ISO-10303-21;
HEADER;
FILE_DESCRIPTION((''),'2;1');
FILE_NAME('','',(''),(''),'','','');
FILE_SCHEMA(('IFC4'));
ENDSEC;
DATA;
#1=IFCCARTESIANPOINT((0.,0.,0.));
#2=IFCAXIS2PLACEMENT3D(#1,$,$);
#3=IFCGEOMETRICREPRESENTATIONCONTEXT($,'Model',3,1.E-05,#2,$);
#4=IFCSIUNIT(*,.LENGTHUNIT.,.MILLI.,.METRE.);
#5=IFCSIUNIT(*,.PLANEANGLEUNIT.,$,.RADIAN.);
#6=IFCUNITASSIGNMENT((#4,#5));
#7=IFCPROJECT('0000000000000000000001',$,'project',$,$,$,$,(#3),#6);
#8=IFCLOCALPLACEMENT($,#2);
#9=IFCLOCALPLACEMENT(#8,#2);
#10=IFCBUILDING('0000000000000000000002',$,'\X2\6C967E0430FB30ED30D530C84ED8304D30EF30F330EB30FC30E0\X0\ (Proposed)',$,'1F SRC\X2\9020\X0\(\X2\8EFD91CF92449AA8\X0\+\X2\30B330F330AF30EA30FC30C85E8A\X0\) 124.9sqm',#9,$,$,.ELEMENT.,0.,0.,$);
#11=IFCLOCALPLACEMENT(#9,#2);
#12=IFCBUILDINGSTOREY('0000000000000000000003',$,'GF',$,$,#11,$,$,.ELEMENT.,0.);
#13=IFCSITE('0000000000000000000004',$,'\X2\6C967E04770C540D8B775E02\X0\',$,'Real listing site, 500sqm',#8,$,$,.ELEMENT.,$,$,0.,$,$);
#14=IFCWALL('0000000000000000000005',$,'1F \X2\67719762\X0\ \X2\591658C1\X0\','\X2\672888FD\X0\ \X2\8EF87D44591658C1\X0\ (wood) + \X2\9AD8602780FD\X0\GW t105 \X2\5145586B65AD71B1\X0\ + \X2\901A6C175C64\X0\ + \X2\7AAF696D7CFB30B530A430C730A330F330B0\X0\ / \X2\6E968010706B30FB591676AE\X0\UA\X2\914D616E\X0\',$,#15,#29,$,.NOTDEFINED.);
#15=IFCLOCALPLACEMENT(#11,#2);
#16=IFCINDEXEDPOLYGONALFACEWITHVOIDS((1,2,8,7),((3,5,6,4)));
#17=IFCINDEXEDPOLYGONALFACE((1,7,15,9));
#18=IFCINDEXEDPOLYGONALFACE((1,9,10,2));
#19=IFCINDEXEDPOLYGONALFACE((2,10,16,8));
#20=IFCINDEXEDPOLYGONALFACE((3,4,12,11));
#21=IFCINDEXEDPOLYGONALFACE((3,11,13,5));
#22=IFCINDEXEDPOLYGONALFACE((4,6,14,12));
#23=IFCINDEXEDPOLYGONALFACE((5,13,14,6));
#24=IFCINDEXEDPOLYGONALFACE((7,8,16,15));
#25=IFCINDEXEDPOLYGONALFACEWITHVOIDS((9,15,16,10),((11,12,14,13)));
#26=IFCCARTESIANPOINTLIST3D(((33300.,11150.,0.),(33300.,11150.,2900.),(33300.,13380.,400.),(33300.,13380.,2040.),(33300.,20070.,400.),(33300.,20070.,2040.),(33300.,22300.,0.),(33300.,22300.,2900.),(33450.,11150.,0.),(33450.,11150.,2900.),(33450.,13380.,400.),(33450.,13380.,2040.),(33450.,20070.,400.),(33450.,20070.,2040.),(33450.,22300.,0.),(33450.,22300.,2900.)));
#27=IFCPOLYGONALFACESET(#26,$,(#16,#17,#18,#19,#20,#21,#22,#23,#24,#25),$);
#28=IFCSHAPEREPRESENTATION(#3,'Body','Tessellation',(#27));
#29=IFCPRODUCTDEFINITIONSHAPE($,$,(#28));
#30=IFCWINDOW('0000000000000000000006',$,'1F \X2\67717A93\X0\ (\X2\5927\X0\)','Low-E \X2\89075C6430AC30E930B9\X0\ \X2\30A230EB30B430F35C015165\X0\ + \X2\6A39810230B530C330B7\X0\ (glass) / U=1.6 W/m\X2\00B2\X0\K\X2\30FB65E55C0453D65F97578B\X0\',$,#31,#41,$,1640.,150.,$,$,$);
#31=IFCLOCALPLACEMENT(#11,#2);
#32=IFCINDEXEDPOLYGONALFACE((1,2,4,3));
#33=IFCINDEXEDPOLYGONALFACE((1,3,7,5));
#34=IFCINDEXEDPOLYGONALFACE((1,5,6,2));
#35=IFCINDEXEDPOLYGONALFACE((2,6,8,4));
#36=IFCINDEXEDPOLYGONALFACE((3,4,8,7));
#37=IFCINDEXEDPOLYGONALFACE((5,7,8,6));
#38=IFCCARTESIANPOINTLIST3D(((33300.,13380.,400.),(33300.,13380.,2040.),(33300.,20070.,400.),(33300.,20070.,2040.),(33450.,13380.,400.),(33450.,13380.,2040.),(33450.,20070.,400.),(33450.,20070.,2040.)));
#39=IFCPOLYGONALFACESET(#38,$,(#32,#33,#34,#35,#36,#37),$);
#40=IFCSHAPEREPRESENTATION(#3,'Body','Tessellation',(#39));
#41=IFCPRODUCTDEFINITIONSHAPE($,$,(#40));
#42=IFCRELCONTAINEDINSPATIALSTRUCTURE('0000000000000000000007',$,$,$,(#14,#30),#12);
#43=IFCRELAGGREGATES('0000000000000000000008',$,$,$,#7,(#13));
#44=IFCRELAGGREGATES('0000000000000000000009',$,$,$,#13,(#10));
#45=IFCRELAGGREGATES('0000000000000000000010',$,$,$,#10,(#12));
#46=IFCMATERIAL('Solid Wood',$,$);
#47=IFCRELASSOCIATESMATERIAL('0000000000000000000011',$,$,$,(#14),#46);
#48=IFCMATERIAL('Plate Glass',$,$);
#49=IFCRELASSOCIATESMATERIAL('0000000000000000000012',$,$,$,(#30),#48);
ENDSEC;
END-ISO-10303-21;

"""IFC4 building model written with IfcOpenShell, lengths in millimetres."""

from ifc_helpers import new_model, si_unit, frame, frame_2d, origin, place, context, project, spatial, rectangle, extrude, material, element, fill, save


model = new_model("IFC4")

# Units and contexts
model_context = context("Model", 3, precision=1e-05, world=origin())
ifc_project = project(units=[si_unit("LENGTHUNIT", "METRE", prefix="MILLI"), si_unit("PLANEANGLEUNIT", "RADIAN")], contexts=[model_context])

# Site, building, storey
site_placement = place(None, origin())
site = spatial("IfcSite", under=ifc_project, at=site_placement, Name="沖縄県名護市", ObjectType="Real listing site, 500sqm", CompositionType="ELEMENT", RefElevation=0.0)
building_placement = place(site_placement, origin())
building = spatial("IfcBuilding", under=site, at=building_placement, Name="沖縄・ロフト付きワンルーム (Proposed)", ObjectType="1F SRC造(軽量鉄骨+コンクリート床) 124.9sqm", CompositionType="ELEMENT", ElevationOfRefHeight=0.0, ElevationOfTerrain=0.0)
storey_placement = place(building_placement, origin())
storey = spatial("IfcBuildingStorey", under=building, at=storey_placement, Name="GF", CompositionType="ELEMENT", Elevation=0.0)

# Shared definitions
ifc_material_1 = material(Name="Solid Wood")

# Wall, opening, window
wall_1_placement = place(storey_placement, frame((16650.0, 5575.0, 0.0)))
wall_1 = element("IfcWall", 1, at=wall_1_placement, inside=storey, material=ifc_material_1, Name="1F 東面 外壁", Description="木製 軸組外壁 (wood) + 高性能GW t105 充填断熱 + 通気層 + 窯業系サイディング / 準耐火・外皮UA配慮", PredefinedType="NOTDEFINED", context=model_context, shape_type="SweptSolid", body=[
    extrude(rectangle(XDim=150.0, YDim=11150.0, at=frame_2d((75.0, 5575.0))), frame((16650.0, 5575.0, 0.0)), (0.0, 0.0, 1.0), 2900.0),
])
opening_placement = place(storey_placement, frame((16650.0, 6690.0, 200.0)))
opening = element("IfcOpeningElement", 2, at=opening_placement, cuts=wall_1, PredefinedType="NOTDEFINED", context=model_context, shape_type="SweptSolid", body=[
    extrude(rectangle(XDim=150.0, YDim=6690.0, at=frame_2d((75.0, 3345.0))), frame((16650.0, 6690.0, 200.0)), (0.0, 0.0, 1.0), 1640.0),
])
ifc_material_2 = material(Name="Plate Glass")
window_placement = place(storey_placement, frame((16650.0, 6690.0, 200.0)))
window = element("IfcWindow", 3, at=window_placement, inside=storey, material=ifc_material_2, Name="1F 東窓 (大)", Description="Low-E 複層ガラス アルゴン封入 + 樹脂サッシ (glass) / U=1.6 W/m²K・日射取得型", OverallHeight=1640.0, OverallWidth=150.0, context=model_context, shape_type="SweptSolid", body=[
    extrude(rectangle(XDim=150.0, YDim=6690.0, at=frame_2d((75.0, 3345.0))), frame((16650.0, 6690.0, 200.0)), (0.0, 0.0, 1.0), 1640.0),
])
fill(opening, window)

save(model, "model.ifc")
